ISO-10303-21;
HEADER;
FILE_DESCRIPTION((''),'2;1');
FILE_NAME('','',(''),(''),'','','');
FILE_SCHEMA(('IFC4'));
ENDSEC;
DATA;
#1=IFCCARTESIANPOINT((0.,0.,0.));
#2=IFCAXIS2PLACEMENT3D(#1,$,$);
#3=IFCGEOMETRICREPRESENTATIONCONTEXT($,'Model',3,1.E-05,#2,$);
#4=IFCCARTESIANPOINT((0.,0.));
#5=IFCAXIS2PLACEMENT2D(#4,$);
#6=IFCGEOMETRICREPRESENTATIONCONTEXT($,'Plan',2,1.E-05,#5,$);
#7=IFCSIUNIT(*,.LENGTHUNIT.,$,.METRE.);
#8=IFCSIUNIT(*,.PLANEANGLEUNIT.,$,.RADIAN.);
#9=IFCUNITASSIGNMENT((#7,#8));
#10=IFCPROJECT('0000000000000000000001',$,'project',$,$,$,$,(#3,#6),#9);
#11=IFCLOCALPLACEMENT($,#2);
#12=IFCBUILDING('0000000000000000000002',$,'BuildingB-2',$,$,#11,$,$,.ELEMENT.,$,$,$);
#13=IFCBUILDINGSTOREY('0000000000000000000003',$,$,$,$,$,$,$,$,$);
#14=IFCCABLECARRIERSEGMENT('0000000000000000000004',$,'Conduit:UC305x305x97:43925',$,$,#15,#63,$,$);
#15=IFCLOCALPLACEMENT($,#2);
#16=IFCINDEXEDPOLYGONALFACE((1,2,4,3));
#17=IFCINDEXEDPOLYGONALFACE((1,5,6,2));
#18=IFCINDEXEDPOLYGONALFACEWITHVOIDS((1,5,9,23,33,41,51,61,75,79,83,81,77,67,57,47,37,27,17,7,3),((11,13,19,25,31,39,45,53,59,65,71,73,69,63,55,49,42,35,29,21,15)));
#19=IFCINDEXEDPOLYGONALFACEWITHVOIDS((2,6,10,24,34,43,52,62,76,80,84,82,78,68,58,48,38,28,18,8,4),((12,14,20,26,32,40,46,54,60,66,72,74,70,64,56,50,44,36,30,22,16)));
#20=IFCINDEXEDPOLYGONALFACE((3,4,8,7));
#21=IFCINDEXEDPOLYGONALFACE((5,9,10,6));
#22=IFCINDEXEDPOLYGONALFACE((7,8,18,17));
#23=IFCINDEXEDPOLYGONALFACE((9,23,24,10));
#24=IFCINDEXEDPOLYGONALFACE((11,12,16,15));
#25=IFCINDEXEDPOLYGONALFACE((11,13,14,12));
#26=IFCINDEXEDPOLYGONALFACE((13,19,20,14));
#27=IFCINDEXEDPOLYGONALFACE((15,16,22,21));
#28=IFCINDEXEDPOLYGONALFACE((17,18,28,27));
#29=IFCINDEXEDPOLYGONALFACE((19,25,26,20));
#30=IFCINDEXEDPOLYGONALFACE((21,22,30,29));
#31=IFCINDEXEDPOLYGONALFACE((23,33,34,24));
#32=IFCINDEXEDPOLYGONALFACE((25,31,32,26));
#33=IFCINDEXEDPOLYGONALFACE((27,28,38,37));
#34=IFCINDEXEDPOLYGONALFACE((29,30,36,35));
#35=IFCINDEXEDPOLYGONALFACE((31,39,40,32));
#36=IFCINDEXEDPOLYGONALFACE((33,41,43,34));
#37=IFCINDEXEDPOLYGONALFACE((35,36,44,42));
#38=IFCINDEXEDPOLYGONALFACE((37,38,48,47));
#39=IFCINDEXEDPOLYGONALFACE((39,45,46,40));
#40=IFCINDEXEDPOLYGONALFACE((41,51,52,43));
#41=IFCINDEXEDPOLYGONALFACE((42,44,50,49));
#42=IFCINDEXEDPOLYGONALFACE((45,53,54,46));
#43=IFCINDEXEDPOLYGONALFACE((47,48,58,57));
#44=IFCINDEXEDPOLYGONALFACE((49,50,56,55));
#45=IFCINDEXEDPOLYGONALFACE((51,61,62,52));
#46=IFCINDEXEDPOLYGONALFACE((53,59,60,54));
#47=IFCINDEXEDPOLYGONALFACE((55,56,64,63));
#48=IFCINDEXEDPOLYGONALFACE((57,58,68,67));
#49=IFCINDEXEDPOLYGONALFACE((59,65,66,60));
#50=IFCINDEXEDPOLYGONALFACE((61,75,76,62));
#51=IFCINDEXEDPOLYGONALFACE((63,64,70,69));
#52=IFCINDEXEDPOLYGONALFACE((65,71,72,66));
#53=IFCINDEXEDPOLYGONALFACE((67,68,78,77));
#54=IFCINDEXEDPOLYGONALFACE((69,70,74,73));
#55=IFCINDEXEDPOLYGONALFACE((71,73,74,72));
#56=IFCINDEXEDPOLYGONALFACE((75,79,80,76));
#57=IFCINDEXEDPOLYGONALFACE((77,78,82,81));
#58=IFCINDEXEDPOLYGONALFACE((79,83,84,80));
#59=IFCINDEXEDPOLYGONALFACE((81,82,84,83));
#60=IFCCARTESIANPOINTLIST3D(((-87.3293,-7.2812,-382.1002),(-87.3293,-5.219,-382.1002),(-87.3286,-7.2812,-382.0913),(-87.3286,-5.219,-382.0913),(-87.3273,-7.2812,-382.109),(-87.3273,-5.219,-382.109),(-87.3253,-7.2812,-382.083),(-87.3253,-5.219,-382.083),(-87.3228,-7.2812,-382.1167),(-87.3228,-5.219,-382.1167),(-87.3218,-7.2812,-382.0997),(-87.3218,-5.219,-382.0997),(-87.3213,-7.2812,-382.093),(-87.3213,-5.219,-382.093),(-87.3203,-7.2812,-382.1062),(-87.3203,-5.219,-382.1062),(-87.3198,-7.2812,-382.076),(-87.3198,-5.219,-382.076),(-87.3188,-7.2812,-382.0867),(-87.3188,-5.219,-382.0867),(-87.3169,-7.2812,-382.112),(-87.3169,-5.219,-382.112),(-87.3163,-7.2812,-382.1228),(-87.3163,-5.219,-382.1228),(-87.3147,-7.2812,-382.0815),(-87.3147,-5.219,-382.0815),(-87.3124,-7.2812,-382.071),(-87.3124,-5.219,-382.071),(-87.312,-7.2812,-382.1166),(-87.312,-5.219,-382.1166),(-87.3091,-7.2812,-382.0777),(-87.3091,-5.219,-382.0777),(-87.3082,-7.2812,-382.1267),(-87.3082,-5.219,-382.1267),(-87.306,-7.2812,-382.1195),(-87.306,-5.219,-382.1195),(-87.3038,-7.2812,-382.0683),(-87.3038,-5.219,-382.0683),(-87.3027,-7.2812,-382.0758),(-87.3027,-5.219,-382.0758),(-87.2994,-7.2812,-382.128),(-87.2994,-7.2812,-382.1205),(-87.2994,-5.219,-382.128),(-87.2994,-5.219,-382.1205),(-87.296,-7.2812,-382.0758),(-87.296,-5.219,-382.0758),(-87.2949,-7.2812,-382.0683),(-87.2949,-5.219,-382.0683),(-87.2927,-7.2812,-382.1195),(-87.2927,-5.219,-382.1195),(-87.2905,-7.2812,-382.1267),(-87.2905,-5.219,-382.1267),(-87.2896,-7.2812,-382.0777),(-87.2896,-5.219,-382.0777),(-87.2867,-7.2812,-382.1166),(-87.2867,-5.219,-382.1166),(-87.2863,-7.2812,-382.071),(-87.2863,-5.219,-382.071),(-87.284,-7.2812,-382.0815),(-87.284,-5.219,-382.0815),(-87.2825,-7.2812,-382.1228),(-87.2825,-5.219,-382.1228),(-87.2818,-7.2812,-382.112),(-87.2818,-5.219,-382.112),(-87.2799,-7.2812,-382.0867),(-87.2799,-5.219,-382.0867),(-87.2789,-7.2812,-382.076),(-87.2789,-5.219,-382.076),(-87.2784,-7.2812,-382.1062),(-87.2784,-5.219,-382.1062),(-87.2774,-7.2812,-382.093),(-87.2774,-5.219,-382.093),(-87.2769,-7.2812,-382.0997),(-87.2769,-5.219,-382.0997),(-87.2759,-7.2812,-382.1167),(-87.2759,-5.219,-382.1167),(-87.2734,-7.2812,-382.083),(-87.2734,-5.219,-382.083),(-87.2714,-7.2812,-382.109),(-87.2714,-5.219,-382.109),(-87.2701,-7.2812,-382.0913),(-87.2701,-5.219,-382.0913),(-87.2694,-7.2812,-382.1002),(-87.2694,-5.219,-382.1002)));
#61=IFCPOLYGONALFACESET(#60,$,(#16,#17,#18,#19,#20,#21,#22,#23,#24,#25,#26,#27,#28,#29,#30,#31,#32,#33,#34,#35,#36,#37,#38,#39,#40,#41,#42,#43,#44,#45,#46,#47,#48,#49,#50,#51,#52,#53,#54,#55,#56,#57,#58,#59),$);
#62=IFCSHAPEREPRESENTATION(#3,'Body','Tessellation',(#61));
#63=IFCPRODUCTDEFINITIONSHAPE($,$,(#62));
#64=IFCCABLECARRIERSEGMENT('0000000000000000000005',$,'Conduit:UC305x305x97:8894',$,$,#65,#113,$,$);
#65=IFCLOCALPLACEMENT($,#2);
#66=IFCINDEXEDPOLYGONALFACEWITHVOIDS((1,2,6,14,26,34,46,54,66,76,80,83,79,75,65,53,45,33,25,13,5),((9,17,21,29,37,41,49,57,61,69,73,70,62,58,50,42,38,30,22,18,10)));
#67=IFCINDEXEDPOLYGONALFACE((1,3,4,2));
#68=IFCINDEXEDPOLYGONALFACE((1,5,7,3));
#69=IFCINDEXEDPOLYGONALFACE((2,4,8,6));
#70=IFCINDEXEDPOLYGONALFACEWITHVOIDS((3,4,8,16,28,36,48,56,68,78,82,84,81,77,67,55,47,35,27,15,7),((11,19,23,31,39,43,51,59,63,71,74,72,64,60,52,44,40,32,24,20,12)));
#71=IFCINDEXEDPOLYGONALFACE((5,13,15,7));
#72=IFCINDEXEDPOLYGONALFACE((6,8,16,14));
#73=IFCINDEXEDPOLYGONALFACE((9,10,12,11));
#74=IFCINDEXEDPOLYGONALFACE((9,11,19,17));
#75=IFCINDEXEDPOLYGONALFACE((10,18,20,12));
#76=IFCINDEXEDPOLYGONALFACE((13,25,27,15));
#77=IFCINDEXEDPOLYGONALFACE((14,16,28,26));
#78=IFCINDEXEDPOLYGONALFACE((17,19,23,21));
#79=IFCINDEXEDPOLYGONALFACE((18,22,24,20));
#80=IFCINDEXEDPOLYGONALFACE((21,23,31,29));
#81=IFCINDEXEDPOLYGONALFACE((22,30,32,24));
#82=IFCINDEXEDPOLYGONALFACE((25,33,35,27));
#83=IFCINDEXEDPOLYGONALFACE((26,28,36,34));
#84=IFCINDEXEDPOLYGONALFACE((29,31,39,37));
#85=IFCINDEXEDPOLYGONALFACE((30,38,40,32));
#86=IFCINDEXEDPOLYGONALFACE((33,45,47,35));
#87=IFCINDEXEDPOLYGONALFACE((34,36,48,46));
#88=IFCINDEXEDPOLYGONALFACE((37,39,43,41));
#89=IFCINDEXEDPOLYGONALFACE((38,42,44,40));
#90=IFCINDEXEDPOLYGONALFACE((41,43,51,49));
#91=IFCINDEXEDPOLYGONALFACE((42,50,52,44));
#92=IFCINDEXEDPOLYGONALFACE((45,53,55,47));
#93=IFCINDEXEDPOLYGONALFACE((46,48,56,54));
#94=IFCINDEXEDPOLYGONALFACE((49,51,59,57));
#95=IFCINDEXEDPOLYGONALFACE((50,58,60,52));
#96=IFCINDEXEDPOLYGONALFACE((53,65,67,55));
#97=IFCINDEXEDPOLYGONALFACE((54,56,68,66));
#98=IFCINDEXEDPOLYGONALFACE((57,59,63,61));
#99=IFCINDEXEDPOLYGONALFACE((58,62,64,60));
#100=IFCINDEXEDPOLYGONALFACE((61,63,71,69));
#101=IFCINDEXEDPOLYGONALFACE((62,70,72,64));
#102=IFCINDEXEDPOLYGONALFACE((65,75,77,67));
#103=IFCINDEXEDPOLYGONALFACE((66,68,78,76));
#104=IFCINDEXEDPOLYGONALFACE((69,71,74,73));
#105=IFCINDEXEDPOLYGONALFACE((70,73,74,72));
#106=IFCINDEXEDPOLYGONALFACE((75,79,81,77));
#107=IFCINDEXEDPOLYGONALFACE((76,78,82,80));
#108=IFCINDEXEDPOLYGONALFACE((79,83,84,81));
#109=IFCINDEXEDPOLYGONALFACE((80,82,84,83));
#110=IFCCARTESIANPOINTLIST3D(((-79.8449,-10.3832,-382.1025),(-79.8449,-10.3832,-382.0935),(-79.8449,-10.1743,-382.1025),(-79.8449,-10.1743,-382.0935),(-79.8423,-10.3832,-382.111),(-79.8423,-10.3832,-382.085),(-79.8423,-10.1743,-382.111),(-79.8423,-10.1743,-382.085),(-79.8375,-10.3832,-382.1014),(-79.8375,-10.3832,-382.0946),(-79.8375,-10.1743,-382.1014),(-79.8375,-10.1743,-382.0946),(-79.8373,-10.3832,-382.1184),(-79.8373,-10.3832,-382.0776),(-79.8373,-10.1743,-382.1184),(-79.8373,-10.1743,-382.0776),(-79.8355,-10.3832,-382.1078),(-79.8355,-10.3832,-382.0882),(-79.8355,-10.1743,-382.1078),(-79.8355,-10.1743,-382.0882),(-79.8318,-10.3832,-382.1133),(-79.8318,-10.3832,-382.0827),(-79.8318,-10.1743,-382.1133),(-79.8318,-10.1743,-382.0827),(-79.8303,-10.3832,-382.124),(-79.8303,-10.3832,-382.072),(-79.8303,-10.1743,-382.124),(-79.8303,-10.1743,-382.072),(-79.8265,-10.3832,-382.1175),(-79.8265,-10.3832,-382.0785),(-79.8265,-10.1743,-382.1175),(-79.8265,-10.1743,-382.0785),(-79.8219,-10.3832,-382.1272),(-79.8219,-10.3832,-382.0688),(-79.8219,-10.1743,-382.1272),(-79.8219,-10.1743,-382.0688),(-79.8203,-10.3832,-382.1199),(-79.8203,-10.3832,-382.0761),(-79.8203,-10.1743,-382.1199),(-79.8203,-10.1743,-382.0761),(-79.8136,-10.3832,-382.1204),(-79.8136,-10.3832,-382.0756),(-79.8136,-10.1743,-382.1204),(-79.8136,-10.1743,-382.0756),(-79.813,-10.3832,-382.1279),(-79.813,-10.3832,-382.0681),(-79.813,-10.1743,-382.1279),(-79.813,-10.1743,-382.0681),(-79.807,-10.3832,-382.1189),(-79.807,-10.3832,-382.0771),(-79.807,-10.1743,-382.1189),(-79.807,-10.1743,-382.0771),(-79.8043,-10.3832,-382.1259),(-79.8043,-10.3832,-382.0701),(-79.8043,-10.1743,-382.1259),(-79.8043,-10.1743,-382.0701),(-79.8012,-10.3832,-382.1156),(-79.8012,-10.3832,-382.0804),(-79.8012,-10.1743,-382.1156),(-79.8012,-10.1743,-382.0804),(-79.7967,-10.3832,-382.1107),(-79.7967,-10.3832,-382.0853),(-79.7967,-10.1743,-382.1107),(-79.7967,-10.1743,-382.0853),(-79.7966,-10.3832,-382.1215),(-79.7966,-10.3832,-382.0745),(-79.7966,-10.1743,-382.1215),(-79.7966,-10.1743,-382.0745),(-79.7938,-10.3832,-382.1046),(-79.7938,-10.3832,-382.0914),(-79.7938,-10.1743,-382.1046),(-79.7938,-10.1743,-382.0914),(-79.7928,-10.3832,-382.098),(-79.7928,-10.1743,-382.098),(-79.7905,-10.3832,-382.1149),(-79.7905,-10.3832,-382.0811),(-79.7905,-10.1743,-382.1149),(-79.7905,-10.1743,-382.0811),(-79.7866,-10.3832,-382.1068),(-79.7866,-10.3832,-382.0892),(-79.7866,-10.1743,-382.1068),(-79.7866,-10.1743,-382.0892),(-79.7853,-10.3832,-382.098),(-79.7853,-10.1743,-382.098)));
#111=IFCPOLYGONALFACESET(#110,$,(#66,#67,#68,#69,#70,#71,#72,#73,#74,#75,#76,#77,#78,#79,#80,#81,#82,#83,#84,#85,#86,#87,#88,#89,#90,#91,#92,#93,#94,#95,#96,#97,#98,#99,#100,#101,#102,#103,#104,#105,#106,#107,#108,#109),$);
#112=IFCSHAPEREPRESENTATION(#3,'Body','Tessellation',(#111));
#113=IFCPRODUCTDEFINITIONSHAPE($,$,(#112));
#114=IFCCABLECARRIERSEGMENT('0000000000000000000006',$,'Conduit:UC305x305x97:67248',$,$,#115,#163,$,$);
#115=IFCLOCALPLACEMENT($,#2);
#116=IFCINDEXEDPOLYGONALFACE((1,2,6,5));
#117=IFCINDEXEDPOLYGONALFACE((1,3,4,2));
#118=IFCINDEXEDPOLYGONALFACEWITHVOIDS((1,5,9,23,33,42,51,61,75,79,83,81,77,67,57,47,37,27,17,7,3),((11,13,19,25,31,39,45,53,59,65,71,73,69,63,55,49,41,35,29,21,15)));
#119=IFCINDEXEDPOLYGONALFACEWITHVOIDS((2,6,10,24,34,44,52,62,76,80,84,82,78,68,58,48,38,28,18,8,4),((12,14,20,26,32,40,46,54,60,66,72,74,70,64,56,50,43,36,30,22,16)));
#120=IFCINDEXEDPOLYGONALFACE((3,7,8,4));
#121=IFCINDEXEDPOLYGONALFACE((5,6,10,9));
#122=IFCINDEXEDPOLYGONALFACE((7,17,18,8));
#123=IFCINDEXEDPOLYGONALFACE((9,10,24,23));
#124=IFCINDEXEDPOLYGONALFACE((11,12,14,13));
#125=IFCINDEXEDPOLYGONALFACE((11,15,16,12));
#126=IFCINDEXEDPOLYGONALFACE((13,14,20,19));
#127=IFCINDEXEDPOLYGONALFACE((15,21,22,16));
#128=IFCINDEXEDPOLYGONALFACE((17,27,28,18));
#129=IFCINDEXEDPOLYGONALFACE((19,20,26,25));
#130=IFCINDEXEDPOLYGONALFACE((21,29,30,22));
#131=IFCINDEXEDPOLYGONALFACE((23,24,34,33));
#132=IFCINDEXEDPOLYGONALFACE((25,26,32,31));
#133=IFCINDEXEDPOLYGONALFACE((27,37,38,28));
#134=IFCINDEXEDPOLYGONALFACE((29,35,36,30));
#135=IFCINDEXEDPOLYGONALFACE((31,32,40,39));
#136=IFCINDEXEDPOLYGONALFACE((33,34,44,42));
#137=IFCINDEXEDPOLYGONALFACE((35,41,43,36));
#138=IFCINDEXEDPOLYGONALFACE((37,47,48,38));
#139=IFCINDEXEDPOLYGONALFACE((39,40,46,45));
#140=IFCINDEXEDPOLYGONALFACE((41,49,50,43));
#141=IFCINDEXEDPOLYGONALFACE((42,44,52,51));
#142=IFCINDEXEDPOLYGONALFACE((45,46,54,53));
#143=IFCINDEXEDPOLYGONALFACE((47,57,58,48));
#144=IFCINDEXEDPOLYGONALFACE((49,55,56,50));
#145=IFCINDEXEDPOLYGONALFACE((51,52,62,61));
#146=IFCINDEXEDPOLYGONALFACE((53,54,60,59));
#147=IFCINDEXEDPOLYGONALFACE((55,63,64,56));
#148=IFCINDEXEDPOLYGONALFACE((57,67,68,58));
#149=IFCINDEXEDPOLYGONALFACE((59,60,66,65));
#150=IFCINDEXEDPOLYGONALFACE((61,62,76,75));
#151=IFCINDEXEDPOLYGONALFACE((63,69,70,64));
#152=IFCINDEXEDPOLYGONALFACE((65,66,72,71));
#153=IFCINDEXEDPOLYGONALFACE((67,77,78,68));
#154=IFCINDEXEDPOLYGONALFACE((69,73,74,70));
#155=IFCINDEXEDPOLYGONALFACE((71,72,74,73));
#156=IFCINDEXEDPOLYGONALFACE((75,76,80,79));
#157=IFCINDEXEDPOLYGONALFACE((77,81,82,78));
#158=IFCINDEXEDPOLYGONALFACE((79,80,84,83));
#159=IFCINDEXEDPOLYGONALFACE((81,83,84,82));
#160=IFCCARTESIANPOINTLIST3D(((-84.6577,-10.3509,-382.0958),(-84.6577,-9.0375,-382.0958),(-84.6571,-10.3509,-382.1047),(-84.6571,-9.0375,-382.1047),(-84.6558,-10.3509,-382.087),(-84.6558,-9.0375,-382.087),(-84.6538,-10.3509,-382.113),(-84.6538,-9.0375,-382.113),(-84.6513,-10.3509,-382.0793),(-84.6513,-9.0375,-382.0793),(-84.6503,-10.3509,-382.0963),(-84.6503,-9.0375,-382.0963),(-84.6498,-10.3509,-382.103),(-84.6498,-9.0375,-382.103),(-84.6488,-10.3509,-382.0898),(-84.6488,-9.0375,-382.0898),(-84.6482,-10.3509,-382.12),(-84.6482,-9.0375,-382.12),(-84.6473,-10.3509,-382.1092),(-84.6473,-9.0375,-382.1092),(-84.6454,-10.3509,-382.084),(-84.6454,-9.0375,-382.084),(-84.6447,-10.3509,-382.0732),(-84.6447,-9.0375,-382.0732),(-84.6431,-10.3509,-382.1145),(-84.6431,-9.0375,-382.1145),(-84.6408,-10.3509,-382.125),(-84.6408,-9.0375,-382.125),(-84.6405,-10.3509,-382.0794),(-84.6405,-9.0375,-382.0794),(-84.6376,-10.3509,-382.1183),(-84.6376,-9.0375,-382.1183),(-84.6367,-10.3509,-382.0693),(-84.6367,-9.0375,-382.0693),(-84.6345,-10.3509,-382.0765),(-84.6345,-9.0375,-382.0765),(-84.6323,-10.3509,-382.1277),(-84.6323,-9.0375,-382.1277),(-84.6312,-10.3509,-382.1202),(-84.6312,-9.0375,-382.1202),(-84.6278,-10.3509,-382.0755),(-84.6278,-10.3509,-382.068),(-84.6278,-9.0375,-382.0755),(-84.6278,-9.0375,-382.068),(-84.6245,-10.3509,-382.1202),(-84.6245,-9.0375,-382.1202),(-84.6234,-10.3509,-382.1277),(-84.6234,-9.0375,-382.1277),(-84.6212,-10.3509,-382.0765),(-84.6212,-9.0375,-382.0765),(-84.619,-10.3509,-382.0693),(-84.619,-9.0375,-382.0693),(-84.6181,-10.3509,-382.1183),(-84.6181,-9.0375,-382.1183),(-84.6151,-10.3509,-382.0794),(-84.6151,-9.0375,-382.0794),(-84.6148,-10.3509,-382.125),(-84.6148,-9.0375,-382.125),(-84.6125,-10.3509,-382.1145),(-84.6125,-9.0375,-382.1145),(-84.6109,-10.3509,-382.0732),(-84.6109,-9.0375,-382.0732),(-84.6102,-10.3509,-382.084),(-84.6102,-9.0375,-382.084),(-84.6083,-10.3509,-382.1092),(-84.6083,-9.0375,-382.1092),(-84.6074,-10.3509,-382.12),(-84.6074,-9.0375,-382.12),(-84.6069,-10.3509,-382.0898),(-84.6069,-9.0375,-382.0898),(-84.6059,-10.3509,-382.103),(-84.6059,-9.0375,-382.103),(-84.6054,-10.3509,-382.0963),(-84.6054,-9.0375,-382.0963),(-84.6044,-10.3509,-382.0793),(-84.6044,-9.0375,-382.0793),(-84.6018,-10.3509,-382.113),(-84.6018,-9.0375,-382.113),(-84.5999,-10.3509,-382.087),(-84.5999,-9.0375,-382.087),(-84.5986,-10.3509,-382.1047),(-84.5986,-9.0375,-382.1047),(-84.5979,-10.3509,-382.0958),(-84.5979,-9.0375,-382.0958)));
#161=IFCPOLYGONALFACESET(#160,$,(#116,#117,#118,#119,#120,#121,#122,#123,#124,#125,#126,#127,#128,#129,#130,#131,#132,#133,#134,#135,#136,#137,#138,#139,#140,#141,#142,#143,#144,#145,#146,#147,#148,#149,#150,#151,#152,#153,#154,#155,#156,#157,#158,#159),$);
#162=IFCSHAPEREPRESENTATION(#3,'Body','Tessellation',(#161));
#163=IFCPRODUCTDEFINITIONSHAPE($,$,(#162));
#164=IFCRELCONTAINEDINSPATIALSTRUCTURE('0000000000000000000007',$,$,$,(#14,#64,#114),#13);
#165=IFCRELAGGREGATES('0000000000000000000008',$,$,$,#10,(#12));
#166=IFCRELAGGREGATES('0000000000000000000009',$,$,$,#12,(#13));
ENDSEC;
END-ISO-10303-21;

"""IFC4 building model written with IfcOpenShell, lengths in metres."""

from ifc_helpers import new_model, entity, si_unit, origin, origin_2d, place, context, project, spatial, element, save


model = new_model("IFC4")

# Units and contexts
model_context = context("Model", 3, precision=1e-05, world=origin())
plan_context = context("Plan", 2, precision=1e-05, world=origin_2d())
ifc_project = project(units=[si_unit("LENGTHUNIT", "METRE"), si_unit("PLANEANGLEUNIT", "RADIAN")], contexts=[model_context, plan_context])

# Building, storey
building_placement = place(None, origin())
building = spatial("IfcBuilding", under=ifc_project, at=building_placement, Name="BuildingB-2", CompositionType="ELEMENT")
storey = spatial("IfcBuildingStorey", under=building)

# Cable carrier segments
element("IfcCableCarrierSegment", 1, inside=storey, Name="Conduit:UC305x305x97:43925", context=model_context, shape_type="AdvancedSweptSolid", body=[
    entity("IfcSweptDiskSolid", entity("IfcCompositeCurve", [entity("IfcCompositeCurveSegment", "CONTINUOUS", False, entity("IfcPolyline", [entity("IfcCartesianPoint", [87.2994, 7.2812, 382.098]), entity("IfcCartesianPoint", [87.2994, 5.219, 382.098])]))], False), 0.03, 0.0225),
])
element("IfcCableCarrierSegment", 2, inside=storey, Name="Conduit:UC305x305x97:8894", context=model_context, shape_type="AdvancedSweptSolid", body=[
    entity("IfcSweptDiskSolid", entity("IfcCompositeCurve", [entity("IfcCompositeCurveSegment", "CONTINUOUS", False, entity("IfcPolyline", [entity("IfcCartesianPoint", [79.8153, 10.1743, 382.098]), entity("IfcCartesianPoint", [79.8153, 10.3832, 382.098])]))], False), 0.03, 0.0225),
])
element("IfcCableCarrierSegment", 3, inside=storey, Name="Conduit:UC305x305x97:67248", context=model_context, shape_type="AdvancedSweptSolid", body=[
    entity("IfcSweptDiskSolid", entity("IfcCompositeCurve", [entity("IfcCompositeCurveSegment", "CONTINUOUS", False, entity("IfcPolyline", [entity("IfcCartesianPoint", [84.6278, 9.0375, 382.098]), entity("IfcCartesianPoint", [84.6278, 10.3509, 382.098])]))], False), 0.03, 0.0225),
])

save(model, "model.ifc")
